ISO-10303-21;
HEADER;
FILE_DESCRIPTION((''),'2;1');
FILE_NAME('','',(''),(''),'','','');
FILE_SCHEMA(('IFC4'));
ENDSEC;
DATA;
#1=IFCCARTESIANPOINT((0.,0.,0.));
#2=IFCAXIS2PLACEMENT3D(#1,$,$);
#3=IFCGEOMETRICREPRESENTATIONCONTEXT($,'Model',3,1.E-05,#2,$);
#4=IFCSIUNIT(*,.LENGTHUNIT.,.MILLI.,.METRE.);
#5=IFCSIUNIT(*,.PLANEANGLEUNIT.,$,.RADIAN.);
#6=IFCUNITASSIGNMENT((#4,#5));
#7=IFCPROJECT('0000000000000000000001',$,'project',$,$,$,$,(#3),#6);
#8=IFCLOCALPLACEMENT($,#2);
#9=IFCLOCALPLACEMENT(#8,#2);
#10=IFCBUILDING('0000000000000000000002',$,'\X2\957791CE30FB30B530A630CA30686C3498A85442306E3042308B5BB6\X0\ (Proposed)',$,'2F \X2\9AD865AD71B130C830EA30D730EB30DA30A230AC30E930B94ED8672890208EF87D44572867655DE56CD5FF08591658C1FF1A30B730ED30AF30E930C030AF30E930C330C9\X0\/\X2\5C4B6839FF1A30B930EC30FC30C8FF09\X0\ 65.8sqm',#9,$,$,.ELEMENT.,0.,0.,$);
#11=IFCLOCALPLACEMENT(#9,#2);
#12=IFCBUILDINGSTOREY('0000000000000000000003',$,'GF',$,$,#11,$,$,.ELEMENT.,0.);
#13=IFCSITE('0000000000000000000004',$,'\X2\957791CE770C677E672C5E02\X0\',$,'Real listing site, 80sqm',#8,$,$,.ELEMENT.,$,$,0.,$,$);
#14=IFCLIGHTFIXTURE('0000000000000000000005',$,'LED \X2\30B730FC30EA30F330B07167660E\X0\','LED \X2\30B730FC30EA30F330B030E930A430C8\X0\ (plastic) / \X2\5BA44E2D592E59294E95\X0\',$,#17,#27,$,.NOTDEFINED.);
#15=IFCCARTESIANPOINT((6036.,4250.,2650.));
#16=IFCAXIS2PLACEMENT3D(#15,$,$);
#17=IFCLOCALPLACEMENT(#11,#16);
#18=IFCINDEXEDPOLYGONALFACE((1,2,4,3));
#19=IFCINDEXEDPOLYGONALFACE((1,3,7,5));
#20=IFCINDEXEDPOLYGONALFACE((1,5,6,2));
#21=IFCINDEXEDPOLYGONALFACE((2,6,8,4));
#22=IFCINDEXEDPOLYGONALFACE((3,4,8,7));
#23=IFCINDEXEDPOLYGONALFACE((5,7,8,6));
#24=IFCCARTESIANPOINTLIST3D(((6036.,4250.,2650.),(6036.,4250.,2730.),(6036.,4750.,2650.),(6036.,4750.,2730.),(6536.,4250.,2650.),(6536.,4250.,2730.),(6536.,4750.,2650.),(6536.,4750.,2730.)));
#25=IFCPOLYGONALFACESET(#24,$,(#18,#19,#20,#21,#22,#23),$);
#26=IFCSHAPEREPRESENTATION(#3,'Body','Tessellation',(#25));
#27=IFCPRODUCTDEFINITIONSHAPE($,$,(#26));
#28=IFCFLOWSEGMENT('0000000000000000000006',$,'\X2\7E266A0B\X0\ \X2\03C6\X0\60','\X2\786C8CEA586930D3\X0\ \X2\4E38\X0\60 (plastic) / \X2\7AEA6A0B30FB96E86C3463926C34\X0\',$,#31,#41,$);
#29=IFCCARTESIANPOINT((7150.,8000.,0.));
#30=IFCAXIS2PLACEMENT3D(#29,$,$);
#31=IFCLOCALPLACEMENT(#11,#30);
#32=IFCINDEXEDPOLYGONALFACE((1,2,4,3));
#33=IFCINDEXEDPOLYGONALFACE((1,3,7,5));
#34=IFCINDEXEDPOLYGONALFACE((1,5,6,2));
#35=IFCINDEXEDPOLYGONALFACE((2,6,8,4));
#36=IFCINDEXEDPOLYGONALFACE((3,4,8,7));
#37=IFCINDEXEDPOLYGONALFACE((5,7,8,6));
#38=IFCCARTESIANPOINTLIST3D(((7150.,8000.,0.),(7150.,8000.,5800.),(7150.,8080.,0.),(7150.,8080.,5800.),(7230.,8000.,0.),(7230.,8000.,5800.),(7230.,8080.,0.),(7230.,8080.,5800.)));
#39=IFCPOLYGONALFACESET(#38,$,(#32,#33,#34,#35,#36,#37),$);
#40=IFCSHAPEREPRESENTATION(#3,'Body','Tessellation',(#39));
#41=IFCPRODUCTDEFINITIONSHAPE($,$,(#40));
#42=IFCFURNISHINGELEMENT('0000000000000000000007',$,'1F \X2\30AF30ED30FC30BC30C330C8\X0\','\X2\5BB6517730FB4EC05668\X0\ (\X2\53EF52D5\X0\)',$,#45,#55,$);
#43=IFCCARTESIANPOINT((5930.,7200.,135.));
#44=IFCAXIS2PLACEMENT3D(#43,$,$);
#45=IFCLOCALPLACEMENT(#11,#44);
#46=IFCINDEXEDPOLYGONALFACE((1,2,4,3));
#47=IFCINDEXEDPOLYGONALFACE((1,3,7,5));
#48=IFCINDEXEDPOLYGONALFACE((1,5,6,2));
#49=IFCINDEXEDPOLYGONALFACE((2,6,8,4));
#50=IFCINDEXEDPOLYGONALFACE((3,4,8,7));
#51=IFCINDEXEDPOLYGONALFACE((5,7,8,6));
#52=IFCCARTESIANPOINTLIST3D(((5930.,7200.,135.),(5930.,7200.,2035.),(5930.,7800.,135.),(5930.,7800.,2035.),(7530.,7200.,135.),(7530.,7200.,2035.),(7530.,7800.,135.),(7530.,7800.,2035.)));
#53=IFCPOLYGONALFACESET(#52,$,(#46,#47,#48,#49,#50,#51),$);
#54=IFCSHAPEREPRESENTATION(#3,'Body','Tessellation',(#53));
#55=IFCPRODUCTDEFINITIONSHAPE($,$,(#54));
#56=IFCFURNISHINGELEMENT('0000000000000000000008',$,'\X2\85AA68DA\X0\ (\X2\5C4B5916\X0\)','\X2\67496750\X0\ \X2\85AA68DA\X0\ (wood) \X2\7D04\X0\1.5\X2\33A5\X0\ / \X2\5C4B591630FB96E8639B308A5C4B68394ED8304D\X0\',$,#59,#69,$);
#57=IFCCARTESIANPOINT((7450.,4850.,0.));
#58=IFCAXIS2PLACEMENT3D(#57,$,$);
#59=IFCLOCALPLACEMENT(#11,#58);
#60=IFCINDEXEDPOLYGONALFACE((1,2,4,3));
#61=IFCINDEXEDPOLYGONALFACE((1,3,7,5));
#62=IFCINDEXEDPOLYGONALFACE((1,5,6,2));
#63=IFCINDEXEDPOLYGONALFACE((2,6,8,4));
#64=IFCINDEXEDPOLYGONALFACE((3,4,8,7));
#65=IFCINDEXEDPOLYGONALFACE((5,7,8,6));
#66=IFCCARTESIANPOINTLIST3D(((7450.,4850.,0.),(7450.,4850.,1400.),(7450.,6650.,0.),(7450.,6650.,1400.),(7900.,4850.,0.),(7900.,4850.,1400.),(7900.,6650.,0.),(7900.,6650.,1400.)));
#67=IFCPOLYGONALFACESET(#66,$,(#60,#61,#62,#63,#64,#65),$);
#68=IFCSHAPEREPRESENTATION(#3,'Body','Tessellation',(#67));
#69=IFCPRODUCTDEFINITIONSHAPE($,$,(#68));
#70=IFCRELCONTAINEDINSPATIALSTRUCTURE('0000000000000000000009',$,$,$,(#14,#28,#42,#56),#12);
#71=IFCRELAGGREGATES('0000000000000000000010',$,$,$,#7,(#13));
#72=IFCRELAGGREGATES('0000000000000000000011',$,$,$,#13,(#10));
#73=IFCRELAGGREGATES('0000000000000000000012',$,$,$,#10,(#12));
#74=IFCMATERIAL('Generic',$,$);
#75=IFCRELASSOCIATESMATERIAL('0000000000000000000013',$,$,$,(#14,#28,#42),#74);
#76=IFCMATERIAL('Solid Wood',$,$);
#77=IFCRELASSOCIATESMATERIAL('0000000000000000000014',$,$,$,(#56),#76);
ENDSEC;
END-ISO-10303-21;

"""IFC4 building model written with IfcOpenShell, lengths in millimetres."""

from ifc_helpers import new_model, si_unit, frame, frame_2d, origin, place, context, project, spatial, rectangle, extrude, material, element, save


model = new_model("IFC4")

# Units and contexts
model_context = context("Model", 3, precision=1e-05, world=origin())
ifc_project = project(units=[si_unit("LENGTHUNIT", "METRE", prefix="MILLI"), si_unit("PLANEANGLEUNIT", "RADIAN")], contexts=[model_context])

# Site, building, storey
site_placement = place(None, origin())
site = spatial("IfcSite", under=ifc_project, at=site_placement, Name="長野県松本市", ObjectType="Real listing site, 80sqm", CompositionType="ELEMENT", RefElevation=0.0)
building_placement = place(site_placement, origin())
building = spatial("IfcBuilding", under=site, at=building_placement, Name="長野・サウナと水風呂のある家 (Proposed)", ObjectType="2F 高断熱トリプルペアガラス付木造軸組在来工法（外壁：シロクラダクラッド/屋根：スレート） 65.8sqm", CompositionType="ELEMENT", ElevationOfRefHeight=0.0, ElevationOfTerrain=0.0)
storey_placement = place(building_placement, origin())
storey = spatial("IfcBuildingStorey", under=building, at=storey_placement, Name="GF", CompositionType="ELEMENT", Elevation=0.0)

# Shared definitions
ifc_material_1 = material(Name="Solid Wood")

# Shared definitions
ifc_material_2 = material(Name="Generic")

# Light fixture
light_fixture_placement = place(storey_placement, frame((6036.0, 4250.0, 2650.0)))
element("IfcLightFixture", 1, at=light_fixture_placement, inside=storey, material=ifc_material_2, Name="LED シーリング照明", Description="LED シーリングライト (plastic) / 室中央天井", PredefinedType="NOTDEFINED", context=model_context, shape_type="SweptSolid", body=[
    extrude(rectangle(XDim=500.0, YDim=500.0, at=frame_2d((250.0, 250.0))), frame((6036.0, 4250.0, 2650.0)), (0.0, 0.0, 1.0), 80.0),
])

# Flow segment
flow_segment_placement = place(storey_placement, frame((7150.0, 8000.0, 0.0)))
element("IfcFlowSegment", 2, at=flow_segment_placement, inside=storey, material=ifc_material_2, Name="縦樋 φ60", Description="硬質塩ビ 丸60 (plastic) / 竪樋・雨水排水", context=model_context, shape_type="SweptSolid", body=[
    extrude(rectangle(XDim=80.0, YDim=80.0, at=frame_2d((40.0, 40.0))), frame((7150.0, 8000.0, 0.0)), (0.0, 0.0, 1.0), 5800.0),
])

# Furnishing elements
furnishing_1_placement = place(storey_placement, frame((5930.0, 7200.0, 135.0)))
element("IfcFurnishingElement", 3, at=furnishing_1_placement, inside=storey, material=ifc_material_2, Name="1F クローゼット", Description="家具・什器 (可動)", context=model_context, shape_type="SweptSolid", body=[
    extrude(rectangle(XDim=1600.0, YDim=600.0, at=frame_2d((800.0, 300.0))), frame((5930.0, 7200.0, 135.0)), (0.0, 0.0, 1.0), 1900.0),
])
furnishing_2_placement = place(storey_placement, frame((7450.0, 4850.0, 0.0)))
element("IfcFurnishingElement", 4, at=furnishing_2_placement, inside=storey, material=ifc_material_1, Name="薪棚 (屋外)", Description="杉材 薪棚 (wood) 約1.5㎥ / 屋外・雨掛り屋根付き", context=model_context, shape_type="SweptSolid", body=[
    extrude(rectangle(XDim=450.0, YDim=1800.0, at=frame_2d((225.0, 900.0))), frame((7450.0, 4850.0, 0.0)), (0.0, 0.0, 1.0), 1400.0),
])

save(model, "model.ifc")
